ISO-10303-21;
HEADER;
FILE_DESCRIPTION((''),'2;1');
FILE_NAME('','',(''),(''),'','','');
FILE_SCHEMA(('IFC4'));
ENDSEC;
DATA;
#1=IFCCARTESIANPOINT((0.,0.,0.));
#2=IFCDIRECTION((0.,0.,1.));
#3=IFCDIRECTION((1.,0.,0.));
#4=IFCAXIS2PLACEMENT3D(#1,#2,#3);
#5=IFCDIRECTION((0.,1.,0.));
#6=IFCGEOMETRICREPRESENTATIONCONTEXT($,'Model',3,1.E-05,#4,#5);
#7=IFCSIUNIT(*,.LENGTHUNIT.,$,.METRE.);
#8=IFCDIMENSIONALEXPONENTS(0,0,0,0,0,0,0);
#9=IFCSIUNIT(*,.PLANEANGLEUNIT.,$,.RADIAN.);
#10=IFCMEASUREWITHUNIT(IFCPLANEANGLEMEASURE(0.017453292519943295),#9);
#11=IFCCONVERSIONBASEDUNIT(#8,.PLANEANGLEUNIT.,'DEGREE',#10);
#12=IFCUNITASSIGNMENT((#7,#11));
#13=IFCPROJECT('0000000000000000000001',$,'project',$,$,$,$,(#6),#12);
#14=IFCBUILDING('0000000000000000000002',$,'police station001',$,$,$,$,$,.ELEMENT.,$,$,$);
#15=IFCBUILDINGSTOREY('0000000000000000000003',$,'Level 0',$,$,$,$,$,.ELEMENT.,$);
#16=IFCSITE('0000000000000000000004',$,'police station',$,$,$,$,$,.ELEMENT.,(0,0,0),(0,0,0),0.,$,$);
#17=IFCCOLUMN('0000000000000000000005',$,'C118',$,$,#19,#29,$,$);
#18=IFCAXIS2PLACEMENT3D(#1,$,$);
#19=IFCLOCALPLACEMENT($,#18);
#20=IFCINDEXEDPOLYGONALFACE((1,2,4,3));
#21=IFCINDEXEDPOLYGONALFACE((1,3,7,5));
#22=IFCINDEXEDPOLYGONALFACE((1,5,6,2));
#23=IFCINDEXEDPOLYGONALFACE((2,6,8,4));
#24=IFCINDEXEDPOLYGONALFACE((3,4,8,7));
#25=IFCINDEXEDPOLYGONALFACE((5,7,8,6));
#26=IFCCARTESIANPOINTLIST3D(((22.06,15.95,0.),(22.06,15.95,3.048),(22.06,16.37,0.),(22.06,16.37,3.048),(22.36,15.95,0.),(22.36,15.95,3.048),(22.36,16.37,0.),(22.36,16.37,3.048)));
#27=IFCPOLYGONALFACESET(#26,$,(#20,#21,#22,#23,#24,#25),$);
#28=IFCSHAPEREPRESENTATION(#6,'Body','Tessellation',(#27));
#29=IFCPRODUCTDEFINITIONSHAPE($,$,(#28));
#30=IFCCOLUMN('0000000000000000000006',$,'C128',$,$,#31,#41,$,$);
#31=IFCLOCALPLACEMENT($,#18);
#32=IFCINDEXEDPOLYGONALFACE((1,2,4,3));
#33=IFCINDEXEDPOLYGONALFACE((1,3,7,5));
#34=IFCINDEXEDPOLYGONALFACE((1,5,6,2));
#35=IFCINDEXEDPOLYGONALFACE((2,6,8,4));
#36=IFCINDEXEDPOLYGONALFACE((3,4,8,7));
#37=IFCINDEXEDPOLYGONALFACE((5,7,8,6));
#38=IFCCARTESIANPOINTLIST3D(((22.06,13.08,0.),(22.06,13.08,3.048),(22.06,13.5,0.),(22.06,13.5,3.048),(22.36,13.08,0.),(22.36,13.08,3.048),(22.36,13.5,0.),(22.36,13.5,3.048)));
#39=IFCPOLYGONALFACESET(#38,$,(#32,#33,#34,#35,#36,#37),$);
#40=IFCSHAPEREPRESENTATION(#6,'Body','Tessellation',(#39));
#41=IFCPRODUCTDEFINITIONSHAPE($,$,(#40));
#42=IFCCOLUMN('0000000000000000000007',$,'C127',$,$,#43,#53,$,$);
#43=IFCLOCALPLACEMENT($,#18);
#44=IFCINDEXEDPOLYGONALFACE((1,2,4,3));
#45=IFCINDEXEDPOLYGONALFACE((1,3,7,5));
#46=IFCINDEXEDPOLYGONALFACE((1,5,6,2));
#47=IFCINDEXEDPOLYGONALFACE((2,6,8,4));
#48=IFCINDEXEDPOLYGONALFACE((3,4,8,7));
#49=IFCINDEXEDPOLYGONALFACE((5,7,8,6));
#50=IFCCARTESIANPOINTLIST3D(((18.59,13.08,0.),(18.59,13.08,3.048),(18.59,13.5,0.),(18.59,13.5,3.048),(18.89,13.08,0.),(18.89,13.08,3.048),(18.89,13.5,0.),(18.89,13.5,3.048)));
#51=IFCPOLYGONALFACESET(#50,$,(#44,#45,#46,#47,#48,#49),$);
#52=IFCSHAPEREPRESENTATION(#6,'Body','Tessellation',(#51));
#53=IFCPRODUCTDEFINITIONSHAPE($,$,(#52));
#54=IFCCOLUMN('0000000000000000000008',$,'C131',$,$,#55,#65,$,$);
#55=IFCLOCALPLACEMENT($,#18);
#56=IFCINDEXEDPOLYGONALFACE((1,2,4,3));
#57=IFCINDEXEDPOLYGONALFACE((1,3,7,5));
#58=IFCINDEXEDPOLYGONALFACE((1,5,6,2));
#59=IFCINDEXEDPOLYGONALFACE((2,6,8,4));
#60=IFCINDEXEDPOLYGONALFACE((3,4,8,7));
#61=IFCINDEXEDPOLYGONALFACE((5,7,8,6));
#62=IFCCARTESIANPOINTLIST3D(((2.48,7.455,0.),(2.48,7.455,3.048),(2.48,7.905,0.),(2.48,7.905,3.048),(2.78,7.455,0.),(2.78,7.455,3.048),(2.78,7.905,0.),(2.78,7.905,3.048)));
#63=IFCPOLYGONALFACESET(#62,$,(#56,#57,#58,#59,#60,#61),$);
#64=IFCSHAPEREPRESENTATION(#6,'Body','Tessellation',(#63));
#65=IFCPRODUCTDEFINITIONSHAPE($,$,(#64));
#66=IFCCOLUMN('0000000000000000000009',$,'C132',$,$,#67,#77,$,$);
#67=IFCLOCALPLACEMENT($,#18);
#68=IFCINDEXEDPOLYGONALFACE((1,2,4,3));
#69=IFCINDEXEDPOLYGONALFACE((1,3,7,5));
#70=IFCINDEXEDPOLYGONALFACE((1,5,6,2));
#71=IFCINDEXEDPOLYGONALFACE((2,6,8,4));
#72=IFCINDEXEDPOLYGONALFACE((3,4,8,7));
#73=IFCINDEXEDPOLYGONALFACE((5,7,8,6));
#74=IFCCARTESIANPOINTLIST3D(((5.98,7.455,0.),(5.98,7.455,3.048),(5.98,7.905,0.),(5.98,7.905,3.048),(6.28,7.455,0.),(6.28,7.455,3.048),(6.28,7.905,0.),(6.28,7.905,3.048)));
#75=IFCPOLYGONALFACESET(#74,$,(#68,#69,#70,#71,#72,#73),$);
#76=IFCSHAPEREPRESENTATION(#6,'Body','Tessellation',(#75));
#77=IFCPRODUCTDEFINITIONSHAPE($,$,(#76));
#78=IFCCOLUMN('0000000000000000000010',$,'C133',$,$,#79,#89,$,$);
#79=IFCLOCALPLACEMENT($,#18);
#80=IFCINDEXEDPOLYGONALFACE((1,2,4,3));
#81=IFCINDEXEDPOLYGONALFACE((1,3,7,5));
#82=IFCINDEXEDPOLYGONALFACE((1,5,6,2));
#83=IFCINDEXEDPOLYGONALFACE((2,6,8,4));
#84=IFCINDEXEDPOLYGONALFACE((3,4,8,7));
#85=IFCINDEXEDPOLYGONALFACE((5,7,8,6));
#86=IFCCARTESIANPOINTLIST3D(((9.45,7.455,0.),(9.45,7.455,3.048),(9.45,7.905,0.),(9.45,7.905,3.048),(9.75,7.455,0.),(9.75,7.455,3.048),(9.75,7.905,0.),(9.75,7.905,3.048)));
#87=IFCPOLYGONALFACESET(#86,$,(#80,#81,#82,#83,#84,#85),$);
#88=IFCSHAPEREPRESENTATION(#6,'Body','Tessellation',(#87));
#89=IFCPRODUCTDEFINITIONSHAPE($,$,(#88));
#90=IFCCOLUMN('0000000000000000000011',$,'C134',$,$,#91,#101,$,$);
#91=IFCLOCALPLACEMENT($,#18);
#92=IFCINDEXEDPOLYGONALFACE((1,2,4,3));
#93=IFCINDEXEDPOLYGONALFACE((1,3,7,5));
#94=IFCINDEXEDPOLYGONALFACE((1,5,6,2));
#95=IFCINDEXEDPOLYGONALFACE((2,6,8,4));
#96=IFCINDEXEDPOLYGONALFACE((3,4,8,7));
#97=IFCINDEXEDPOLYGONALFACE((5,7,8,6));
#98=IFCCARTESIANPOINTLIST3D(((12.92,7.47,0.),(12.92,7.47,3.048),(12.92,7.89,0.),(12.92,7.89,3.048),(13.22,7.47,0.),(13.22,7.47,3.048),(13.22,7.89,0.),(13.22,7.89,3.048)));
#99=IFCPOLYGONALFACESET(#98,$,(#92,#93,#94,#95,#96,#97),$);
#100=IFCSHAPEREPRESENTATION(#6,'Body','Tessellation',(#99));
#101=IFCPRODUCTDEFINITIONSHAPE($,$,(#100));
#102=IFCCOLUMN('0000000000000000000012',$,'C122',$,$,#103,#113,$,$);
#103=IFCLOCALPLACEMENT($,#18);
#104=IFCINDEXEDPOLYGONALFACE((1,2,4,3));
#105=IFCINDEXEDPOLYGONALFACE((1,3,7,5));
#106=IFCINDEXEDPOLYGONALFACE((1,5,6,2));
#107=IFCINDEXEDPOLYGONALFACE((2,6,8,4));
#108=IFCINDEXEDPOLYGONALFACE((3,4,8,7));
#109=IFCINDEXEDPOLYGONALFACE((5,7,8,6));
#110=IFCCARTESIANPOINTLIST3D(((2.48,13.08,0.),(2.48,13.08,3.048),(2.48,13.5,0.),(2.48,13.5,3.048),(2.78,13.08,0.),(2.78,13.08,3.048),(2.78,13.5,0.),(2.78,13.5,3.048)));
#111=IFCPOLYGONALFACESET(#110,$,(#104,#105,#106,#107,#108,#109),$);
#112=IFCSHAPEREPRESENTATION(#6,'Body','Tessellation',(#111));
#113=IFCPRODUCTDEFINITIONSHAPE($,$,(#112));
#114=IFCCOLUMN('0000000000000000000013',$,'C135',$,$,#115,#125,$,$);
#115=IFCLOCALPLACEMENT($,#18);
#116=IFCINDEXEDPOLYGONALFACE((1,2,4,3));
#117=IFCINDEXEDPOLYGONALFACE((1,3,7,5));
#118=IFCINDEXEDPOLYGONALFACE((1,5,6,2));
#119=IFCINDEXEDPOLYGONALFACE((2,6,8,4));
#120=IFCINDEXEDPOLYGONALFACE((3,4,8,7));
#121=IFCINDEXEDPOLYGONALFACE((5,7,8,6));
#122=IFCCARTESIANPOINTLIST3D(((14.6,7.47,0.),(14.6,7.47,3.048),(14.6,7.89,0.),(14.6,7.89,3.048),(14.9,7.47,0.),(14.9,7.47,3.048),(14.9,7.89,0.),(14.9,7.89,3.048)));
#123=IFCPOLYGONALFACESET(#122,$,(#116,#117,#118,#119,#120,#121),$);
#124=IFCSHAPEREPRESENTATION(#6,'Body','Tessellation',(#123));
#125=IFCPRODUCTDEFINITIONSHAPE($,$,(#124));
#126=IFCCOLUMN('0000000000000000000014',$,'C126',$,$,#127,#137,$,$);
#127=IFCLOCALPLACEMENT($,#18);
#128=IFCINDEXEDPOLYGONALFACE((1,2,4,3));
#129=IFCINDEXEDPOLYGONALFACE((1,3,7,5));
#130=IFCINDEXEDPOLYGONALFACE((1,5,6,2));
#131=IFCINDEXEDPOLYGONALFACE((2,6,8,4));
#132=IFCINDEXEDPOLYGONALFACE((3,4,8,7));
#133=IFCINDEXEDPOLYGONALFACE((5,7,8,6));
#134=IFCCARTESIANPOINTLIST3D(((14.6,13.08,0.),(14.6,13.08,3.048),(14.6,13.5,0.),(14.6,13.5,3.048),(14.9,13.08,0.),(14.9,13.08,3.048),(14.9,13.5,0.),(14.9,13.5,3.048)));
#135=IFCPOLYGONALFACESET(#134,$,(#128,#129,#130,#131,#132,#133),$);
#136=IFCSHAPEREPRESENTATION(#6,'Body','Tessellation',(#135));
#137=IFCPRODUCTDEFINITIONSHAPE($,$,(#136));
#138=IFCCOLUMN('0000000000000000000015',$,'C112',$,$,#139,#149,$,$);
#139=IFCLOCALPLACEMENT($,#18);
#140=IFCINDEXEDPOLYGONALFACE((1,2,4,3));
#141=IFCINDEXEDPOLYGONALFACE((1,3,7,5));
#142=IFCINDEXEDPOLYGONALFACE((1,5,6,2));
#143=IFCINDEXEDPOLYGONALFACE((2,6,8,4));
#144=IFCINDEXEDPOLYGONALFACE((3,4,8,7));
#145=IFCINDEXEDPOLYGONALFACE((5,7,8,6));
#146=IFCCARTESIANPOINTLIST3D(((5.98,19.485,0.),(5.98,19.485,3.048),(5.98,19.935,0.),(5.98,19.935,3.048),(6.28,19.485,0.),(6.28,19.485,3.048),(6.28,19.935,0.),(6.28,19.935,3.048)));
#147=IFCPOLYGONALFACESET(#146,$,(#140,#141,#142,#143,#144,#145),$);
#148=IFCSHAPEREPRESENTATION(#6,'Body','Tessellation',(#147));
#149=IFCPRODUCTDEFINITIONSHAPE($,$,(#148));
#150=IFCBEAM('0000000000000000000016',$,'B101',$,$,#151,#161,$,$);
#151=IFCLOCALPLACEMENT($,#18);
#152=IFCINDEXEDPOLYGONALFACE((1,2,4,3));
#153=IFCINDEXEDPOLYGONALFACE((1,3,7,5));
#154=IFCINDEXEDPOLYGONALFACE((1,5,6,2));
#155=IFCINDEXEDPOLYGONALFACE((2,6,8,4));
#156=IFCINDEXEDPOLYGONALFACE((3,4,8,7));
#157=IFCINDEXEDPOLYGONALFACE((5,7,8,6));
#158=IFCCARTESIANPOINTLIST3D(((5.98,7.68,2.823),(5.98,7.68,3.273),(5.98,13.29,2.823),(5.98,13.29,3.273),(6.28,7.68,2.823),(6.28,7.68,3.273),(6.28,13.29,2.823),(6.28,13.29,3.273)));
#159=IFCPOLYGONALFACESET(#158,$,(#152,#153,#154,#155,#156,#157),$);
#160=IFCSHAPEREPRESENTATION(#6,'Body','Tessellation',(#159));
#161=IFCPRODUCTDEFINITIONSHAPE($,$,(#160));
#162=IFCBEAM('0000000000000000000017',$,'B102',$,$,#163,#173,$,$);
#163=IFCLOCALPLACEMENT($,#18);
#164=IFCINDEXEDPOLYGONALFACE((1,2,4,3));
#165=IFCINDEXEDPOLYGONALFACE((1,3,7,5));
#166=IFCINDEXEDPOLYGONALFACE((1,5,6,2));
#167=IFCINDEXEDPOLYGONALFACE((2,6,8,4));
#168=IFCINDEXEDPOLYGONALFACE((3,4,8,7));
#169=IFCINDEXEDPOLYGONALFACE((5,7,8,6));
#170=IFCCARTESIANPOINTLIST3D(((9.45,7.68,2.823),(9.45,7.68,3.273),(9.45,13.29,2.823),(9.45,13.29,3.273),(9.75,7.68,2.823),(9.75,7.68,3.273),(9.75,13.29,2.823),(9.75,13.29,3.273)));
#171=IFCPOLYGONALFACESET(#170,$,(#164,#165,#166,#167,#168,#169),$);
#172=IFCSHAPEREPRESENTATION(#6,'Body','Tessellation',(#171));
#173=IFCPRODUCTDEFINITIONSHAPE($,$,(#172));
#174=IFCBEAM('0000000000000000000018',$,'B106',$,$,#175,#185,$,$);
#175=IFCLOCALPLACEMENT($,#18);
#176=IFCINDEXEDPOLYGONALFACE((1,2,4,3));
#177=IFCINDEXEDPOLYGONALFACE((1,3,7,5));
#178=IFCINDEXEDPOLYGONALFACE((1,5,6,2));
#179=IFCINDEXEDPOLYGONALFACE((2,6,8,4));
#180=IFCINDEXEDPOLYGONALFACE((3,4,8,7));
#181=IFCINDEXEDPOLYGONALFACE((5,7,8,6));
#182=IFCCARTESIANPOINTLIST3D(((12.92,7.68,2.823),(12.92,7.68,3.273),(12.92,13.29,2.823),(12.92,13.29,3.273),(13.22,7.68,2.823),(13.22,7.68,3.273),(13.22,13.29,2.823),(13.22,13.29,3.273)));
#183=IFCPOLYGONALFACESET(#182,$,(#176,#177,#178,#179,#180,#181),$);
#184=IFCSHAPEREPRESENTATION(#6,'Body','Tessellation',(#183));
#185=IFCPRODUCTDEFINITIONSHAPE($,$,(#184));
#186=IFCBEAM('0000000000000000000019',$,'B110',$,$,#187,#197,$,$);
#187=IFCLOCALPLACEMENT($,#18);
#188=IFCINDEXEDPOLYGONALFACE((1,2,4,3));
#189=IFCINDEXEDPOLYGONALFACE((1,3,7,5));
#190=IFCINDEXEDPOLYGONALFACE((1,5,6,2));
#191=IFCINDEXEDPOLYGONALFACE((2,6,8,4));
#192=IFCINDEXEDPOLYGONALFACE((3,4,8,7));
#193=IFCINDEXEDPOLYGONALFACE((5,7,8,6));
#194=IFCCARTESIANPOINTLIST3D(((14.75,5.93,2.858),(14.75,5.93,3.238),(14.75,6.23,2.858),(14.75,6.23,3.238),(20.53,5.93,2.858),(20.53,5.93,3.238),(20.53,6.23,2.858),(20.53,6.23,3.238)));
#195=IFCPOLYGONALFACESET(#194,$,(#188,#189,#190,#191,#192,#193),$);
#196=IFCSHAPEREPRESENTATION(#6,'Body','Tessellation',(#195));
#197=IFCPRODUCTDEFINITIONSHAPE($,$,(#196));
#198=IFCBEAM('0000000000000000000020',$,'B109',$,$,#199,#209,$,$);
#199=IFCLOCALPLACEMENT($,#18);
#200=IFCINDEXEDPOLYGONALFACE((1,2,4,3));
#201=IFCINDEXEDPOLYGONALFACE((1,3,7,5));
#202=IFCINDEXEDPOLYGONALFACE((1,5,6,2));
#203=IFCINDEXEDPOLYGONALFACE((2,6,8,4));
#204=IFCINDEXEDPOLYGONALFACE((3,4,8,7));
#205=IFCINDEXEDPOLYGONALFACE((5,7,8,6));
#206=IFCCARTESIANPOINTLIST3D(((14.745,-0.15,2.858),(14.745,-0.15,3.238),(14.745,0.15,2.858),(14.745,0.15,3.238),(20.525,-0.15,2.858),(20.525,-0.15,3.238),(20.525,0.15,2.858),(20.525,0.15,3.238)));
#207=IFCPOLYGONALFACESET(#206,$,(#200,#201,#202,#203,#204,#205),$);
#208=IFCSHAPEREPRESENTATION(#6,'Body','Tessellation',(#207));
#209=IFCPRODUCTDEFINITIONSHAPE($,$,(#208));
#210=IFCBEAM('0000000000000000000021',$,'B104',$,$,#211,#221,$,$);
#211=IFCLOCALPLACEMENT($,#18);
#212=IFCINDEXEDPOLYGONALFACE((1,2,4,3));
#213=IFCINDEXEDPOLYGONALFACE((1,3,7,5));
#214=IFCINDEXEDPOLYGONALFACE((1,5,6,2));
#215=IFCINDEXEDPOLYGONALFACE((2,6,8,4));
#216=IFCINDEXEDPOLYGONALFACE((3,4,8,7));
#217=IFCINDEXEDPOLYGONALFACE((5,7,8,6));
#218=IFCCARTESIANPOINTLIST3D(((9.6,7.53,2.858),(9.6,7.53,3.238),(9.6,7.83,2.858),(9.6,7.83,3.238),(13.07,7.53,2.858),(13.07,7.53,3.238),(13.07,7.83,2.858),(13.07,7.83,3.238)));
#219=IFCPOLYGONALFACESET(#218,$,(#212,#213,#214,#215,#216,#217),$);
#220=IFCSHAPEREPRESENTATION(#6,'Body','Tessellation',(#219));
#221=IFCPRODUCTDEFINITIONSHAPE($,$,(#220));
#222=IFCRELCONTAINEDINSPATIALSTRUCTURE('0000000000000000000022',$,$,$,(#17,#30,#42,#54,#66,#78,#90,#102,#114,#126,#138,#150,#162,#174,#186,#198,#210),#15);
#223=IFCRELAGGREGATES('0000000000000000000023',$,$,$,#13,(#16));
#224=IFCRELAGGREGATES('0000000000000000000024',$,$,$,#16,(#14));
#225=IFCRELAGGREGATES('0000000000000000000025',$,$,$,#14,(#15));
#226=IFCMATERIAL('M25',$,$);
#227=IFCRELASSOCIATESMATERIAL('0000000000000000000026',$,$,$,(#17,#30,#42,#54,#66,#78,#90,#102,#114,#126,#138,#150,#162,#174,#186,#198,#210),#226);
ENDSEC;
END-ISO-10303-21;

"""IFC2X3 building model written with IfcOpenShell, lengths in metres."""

from ifc_helpers import new_model, entity, si_unit, converted_unit, direction, frame, frame_2d, origin_with_axes, place, context, project, spatial, rectangle, extrude, material, element, save


model = new_model("IFC2X3")

# Units and contexts
model_context = context("Model", 3, precision=1e-05, world=origin_with_axes(), true_north=direction((0.0, 1.0, 0.0)))
ifc_project = project(units=[si_unit("LENGTHUNIT", "METRE"), converted_unit("PLANEANGLEUNIT", "DEGREE", entity("IfcPlaneAngleMeasure", 0.017453292519943295), si_unit("PLANEANGLEUNIT", "RADIAN"), dimensions=[0, 0, 0, 0, 0, 0, 0])], contexts=[model_context])

# Site, building, storey
site = spatial("IfcSite", under=ifc_project, Name="police station", CompositionType="ELEMENT", RefLatitude=(0, 0, 0), RefLongitude=(0, 0, 0), RefElevation=0.0)
building = spatial("IfcBuilding", under=site, Name="police station001", CompositionType="ELEMENT")
storey = spatial("IfcBuildingStorey", under=building, Name="Level 0", CompositionType="ELEMENT")

# Columns
ifc_material = material(Name="M25")
placement = place(None, origin_with_axes())
element("IfcColumn", 1, at=placement, inside=storey, material=ifc_material, Name="C118", context=model_context, shape_type="SweptSolid", body=[
    extrude(rectangle(XDim=0.3, YDim=0.42, at=frame_2d((0.0, 0.0), x_axis=(1.0, 0.0, 0.0))), frame((22.21, 16.16, 0.0), z_axis=(0.0, 0.0, 1.0), x_axis=(1.0, 0.0, 0.0)), (0.0, 0.0, 1.0), 3.048),
])
element("IfcColumn", 2, at=placement, inside=storey, material=ifc_material, Name="C128", context=model_context, shape_type="SweptSolid", body=[
    extrude(rectangle(XDim=0.3, YDim=0.42, at=frame_2d((0.0, 0.0), x_axis=(1.0, 0.0, 0.0))), frame((22.21, 13.29, 0.0), z_axis=(0.0, 0.0, 1.0), x_axis=(1.0, 0.0, 0.0)), (0.0, 0.0, 1.0), 3.048),
])
element("IfcColumn", 3, at=placement, inside=storey, material=ifc_material, Name="C127", context=model_context, shape_type="SweptSolid", body=[
    extrude(rectangle(XDim=0.3, YDim=0.42, at=frame_2d((0.0, 0.0), x_axis=(1.0, 0.0, 0.0))), frame((18.74, 13.29, 0.0), z_axis=(0.0, 0.0, 1.0), x_axis=(1.0, 0.0, 0.0)), (0.0, 0.0, 1.0), 3.048),
])
element("IfcColumn", 4, at=placement, inside=storey, material=ifc_material, Name="C131", context=model_context, shape_type="SweptSolid", body=[
    extrude(rectangle(XDim=0.3, YDim=0.45, at=frame_2d((0.0, 0.0), x_axis=(1.0, 0.0, 0.0))), frame((2.63, 7.68, 0.0), z_axis=(0.0, 0.0, 1.0), x_axis=(1.0, 0.0, 0.0)), (0.0, 0.0, 1.0), 3.048),
])
element("IfcColumn", 5, at=placement, inside=storey, material=ifc_material, Name="C132", context=model_context, shape_type="SweptSolid", body=[
    extrude(rectangle(XDim=0.3, YDim=0.45, at=frame_2d((0.0, 0.0), x_axis=(1.0, 0.0, 0.0))), frame((6.13, 7.68, 0.0), z_axis=(0.0, 0.0, 1.0), x_axis=(1.0, 0.0, 0.0)), (0.0, 0.0, 1.0), 3.048),
])
element("IfcColumn", 6, at=placement, inside=storey, material=ifc_material, Name="C133", context=model_context, shape_type="SweptSolid", body=[
    extrude(rectangle(XDim=0.3, YDim=0.45, at=frame_2d((0.0, 0.0), x_axis=(1.0, 0.0, 0.0))), frame((9.6, 7.68, 0.0), z_axis=(0.0, 0.0, 1.0), x_axis=(1.0, 0.0, 0.0)), (0.0, 0.0, 1.0), 3.048),
])
element("IfcColumn", 7, at=placement, inside=storey, material=ifc_material, Name="C134", context=model_context, shape_type="SweptSolid", body=[
    extrude(rectangle(XDim=0.3, YDim=0.42, at=frame_2d((0.0, 0.0), x_axis=(1.0, 0.0, 0.0))), frame((13.07, 7.68, 0.0), z_axis=(0.0, 0.0, 1.0), x_axis=(1.0, 0.0, 0.0)), (0.0, 0.0, 1.0), 3.048),
])
element("IfcColumn", 8, at=placement, inside=storey, material=ifc_material, Name="C122", context=model_context, shape_type="SweptSolid", body=[
    extrude(rectangle(XDim=0.3, YDim=0.42, at=frame_2d((0.0, 0.0), x_axis=(1.0, 0.0, 0.0))), frame((2.63, 13.29, 0.0), z_axis=(0.0, 0.0, 1.0), x_axis=(1.0, 0.0, 0.0)), (0.0, 0.0, 1.0), 3.048),
])
element("IfcColumn", 9, at=placement, inside=storey, material=ifc_material, Name="C135", context=model_context, shape_type="SweptSolid", body=[
    extrude(rectangle(XDim=0.3, YDim=0.42, at=frame_2d((0.0, 0.0), x_axis=(1.0, 0.0, 0.0))), frame((14.75, 7.68, 0.0), z_axis=(0.0, 0.0, 1.0), x_axis=(1.0, 0.0, 0.0)), (0.0, 0.0, 1.0), 3.048),
])
element("IfcColumn", 10, at=placement, inside=storey, material=ifc_material, Name="C126", context=model_context, shape_type="SweptSolid", body=[
    extrude(rectangle(XDim=0.3, YDim=0.42, at=frame_2d((0.0, 0.0), x_axis=(1.0, 0.0, 0.0))), frame((14.75, 13.29, 0.0), z_axis=(0.0, 0.0, 1.0), x_axis=(1.0, 0.0, 0.0)), (0.0, 0.0, 1.0), 3.048),
])
element("IfcColumn", 11, at=placement, inside=storey, material=ifc_material, Name="C112", context=model_context, shape_type="SweptSolid", body=[
    extrude(rectangle(XDim=0.3, YDim=0.45, at=frame_2d((0.0, 0.0), x_axis=(1.0, 0.0, 0.0))), frame((6.13, 19.71, 0.0), z_axis=(0.0, 0.0, 1.0), x_axis=(1.0, 0.0, 0.0)), (0.0, 0.0, 1.0), 3.048),
])

# Beams
element("IfcBeam", 12, at=placement, inside=storey, material=ifc_material, Name="B101", context=model_context, shape_type="SweptSolid", body=[
    extrude(rectangle(XDim=0.3, YDim=0.45, at=frame_2d((0.0, 0.0), x_axis=(0.0, 1.0, 0.0))), frame((6.13, 7.68, 3.048), z_axis=(0.0, 1.0, 0.0), x_axis=(0.0, 0.0, -1.0)), (0.0, 0.0, 1.0), 5.61),
])
element("IfcBeam", 13, at=placement, inside=storey, material=ifc_material, Name="B102", context=model_context, shape_type="SweptSolid", body=[
    extrude(rectangle(XDim=0.3, YDim=0.45, at=frame_2d((0.0, 0.0), x_axis=(0.0, 1.0, 0.0))), frame((9.6, 7.68, 3.048), z_axis=(0.0, 1.0, 0.0), x_axis=(0.0, 0.0, -1.0)), (0.0, 0.0, 1.0), 5.61),
])
element("IfcBeam", 14, at=placement, inside=storey, material=ifc_material, Name="B106", context=model_context, shape_type="SweptSolid", body=[
    extrude(rectangle(XDim=0.3, YDim=0.45, at=frame_2d((0.0, 0.0), x_axis=(0.0, 1.0, 0.0))), frame((13.07, 13.29, 3.048), z_axis=(0.0, -1.0, 0.0), x_axis=(0.0, 0.0, -1.0)), (0.0, 0.0, 1.0), 5.61),
])
element("IfcBeam", 15, at=placement, inside=storey, material=ifc_material, Name="B110", context=model_context, shape_type="SweptSolid", body=[
    extrude(rectangle(XDim=0.3, YDim=0.38, at=frame_2d((0.0, 0.0), x_axis=(0.0, 1.0, 0.0))), frame((20.53, 6.08, 3.048), z_axis=(-1.0, 0.0, 0.0), x_axis=(0.0, 0.0, -1.0)), (0.0, 0.0, 1.0), 5.78),
])
element("IfcBeam", 16, at=placement, inside=storey, material=ifc_material, Name="B109", context=model_context, shape_type="SweptSolid", body=[
    extrude(rectangle(XDim=0.3, YDim=0.38, at=frame_2d((0.0, 0.0), x_axis=(0.0, 1.0, 0.0))), frame((14.745, 0.0, 3.048), z_axis=(1.0, 0.0, 0.0), x_axis=(0.0, 0.0, -1.0)), (0.0, 0.0, 1.0), 5.78),
])
element("IfcBeam", 17, at=placement, inside=storey, material=ifc_material, Name="B104", context=model_context, shape_type="SweptSolid", body=[
    extrude(rectangle(XDim=0.3, YDim=0.38, at=frame_2d((0.0, 0.0), x_axis=(0.0, 1.0, 0.0))), frame((9.6, 7.68, 3.048), z_axis=(1.0, 0.0, 0.0), x_axis=(0.0, 0.0, -1.0)), (0.0, 0.0, 1.0), 3.47),
])

save(model, "model.ifc")
